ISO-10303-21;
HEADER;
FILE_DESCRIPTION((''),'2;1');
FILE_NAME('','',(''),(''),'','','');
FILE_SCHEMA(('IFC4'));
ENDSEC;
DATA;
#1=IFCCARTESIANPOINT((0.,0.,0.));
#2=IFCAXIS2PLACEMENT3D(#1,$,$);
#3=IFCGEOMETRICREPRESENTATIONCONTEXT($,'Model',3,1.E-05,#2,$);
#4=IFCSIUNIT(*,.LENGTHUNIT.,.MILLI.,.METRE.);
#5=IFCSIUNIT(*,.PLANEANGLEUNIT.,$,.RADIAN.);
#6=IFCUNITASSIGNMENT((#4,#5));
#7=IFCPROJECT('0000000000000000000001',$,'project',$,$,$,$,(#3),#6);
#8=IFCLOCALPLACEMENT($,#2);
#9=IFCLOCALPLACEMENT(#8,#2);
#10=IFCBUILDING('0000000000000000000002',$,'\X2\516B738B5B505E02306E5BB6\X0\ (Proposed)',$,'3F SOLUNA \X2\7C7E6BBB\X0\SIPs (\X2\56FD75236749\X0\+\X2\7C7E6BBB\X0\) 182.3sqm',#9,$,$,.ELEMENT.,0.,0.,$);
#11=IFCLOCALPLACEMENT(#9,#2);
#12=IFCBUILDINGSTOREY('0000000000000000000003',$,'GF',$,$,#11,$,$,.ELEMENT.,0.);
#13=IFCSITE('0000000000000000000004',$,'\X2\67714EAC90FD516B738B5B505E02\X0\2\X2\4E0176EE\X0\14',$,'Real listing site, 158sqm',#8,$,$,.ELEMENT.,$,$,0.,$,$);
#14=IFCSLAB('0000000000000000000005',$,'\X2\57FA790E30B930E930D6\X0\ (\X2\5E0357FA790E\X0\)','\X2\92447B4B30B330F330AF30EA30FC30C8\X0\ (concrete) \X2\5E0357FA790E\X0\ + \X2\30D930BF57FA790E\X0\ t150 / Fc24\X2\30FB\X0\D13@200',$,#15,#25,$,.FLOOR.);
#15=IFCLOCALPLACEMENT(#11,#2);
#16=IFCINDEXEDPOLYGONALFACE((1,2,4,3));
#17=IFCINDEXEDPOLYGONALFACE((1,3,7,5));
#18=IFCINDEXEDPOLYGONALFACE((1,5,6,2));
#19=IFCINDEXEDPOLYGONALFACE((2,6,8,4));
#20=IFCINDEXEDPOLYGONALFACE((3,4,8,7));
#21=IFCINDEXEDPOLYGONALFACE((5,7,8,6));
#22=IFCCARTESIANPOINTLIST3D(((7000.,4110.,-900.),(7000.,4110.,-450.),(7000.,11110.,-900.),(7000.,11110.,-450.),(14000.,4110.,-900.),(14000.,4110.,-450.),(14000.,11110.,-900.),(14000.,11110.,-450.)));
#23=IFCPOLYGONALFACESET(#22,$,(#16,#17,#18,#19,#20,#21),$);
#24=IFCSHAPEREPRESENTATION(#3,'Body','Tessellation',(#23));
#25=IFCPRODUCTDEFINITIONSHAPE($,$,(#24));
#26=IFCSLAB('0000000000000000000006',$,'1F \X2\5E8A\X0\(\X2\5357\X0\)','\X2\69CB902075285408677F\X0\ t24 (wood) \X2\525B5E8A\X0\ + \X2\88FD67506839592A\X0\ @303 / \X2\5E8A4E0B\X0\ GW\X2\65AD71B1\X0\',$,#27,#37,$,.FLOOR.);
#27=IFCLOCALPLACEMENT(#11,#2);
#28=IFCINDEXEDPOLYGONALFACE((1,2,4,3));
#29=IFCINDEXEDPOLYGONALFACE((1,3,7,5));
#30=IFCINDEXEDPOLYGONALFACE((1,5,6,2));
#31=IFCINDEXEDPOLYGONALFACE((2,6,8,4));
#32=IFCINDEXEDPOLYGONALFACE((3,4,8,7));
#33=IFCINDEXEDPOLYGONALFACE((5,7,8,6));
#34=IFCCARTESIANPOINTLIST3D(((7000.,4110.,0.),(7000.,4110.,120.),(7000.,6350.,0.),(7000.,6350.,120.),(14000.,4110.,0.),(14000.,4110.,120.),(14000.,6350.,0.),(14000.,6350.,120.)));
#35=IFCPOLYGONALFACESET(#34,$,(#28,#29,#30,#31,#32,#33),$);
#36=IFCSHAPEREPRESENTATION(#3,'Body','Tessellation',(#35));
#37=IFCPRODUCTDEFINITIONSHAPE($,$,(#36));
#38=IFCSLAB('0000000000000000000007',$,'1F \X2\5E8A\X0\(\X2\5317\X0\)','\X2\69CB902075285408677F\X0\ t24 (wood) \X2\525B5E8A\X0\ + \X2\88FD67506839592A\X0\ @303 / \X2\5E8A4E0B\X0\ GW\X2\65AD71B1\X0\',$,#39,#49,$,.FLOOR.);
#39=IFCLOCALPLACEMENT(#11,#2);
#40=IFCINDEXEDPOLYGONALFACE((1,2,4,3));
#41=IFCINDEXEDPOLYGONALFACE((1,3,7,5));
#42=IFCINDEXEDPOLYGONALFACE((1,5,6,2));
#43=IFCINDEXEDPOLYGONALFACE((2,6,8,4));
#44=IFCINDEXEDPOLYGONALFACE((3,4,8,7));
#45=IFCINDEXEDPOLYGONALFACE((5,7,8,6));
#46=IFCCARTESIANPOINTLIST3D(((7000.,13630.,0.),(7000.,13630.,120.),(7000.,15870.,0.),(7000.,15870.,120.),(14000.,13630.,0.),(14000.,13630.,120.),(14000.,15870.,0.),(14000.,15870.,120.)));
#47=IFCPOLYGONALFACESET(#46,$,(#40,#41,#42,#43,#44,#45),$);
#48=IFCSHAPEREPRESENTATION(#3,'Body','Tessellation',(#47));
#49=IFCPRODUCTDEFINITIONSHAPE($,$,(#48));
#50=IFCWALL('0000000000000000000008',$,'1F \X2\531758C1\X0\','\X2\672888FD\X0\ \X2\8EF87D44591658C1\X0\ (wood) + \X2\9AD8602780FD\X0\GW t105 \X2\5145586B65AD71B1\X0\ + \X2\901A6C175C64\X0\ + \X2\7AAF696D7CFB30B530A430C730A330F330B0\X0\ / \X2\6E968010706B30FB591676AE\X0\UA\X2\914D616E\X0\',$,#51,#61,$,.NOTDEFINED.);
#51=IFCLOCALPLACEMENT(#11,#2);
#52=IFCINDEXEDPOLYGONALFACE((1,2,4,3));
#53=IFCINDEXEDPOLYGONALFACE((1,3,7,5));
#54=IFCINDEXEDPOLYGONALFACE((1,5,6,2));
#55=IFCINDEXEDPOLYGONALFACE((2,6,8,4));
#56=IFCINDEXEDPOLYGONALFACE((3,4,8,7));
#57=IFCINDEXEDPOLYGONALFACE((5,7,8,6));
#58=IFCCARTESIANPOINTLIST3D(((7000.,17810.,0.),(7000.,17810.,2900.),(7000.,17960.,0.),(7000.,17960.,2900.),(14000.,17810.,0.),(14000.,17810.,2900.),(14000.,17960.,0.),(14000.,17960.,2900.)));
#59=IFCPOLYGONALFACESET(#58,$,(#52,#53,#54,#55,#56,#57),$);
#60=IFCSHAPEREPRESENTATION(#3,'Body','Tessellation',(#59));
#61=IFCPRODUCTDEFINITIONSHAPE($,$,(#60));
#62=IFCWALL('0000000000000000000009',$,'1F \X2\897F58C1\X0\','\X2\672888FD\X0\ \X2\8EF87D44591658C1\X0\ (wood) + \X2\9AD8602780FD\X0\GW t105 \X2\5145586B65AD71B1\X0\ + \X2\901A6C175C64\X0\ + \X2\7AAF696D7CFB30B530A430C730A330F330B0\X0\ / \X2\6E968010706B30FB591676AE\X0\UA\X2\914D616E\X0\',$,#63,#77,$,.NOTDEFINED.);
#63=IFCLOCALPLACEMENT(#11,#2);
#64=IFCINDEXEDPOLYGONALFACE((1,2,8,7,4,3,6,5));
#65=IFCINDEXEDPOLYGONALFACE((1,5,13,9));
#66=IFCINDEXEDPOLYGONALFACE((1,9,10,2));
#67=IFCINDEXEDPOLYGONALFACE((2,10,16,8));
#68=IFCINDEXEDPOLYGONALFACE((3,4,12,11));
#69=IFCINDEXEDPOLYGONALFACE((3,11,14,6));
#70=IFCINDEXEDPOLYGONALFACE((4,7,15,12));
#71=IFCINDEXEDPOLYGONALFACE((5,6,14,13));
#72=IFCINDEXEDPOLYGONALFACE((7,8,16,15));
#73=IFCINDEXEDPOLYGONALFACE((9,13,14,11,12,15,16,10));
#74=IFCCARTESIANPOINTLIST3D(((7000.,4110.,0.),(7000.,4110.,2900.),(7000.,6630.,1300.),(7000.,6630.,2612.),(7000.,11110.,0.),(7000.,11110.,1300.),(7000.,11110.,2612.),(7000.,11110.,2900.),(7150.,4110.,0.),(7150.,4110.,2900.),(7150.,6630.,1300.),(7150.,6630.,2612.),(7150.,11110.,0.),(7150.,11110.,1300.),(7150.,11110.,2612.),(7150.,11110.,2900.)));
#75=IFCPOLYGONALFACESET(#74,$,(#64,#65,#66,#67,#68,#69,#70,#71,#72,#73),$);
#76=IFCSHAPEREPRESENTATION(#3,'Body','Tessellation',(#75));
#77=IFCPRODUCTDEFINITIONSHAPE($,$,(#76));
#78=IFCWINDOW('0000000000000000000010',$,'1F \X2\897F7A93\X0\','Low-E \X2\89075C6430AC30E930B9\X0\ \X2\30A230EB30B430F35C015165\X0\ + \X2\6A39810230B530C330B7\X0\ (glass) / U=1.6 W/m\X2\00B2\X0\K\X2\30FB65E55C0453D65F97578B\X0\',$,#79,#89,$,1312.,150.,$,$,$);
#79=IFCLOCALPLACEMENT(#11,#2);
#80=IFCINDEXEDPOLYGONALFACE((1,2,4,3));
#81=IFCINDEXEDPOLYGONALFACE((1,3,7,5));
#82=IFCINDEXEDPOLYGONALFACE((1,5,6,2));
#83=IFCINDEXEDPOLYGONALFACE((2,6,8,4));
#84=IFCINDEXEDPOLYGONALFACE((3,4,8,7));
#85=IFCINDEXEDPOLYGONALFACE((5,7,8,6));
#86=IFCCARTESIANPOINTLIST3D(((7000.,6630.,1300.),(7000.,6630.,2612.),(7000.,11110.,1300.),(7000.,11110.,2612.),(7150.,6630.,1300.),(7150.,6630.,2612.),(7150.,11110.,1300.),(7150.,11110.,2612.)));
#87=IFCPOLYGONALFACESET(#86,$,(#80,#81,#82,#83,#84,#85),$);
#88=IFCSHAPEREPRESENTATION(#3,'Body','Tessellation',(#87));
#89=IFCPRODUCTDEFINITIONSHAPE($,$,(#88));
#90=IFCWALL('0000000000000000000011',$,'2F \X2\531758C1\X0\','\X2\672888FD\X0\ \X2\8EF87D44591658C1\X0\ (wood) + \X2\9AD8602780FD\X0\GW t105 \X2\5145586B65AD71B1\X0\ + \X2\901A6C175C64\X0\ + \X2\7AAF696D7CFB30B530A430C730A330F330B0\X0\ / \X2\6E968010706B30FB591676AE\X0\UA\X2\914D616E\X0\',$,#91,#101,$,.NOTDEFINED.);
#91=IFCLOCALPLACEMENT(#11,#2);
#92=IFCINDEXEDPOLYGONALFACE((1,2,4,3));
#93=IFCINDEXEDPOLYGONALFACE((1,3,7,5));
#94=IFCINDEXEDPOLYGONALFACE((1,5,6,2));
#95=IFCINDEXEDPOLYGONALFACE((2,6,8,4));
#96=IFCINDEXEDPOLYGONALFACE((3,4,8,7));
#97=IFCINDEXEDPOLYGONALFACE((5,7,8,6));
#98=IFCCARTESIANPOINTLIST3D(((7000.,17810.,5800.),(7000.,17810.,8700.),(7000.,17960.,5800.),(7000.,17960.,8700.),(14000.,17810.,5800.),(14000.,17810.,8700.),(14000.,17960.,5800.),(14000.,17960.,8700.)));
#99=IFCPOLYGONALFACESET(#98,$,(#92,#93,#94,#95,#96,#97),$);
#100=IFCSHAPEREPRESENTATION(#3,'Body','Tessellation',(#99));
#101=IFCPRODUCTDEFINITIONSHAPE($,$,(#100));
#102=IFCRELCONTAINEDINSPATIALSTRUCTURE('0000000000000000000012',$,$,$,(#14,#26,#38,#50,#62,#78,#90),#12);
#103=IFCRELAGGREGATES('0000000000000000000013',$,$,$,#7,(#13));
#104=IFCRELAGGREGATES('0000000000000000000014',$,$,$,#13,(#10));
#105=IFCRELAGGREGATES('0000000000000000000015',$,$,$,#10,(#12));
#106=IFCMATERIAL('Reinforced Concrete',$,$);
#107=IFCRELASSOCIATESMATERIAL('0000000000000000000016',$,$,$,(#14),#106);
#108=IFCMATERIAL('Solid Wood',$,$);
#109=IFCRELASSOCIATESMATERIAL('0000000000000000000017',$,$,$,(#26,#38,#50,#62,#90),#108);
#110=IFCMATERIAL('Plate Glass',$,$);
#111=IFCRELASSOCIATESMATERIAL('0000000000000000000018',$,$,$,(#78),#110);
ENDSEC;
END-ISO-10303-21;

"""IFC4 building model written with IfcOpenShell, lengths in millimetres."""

from ifc_helpers import new_model, si_unit, frame, frame_2d, origin, place, context, project, spatial, rectangle, extrude, material, element, fill, save


model = new_model("IFC4")

# Units and contexts
model_context = context("Model", 3, precision=1e-05, world=origin())
ifc_project = project(units=[si_unit("LENGTHUNIT", "METRE", prefix="MILLI"), si_unit("PLANEANGLEUNIT", "RADIAN")], contexts=[model_context])

# Site, building, storey
site_placement = place(None, origin())
site = spatial("IfcSite", under=ifc_project, at=site_placement, Name="東京都八王子市2丁目14", ObjectType="Real listing site, 158sqm", CompositionType="ELEMENT", RefElevation=0.0)
building_placement = place(site_placement, origin())
building = spatial("IfcBuilding", under=site, at=building_placement, Name="八王子市の家 (Proposed)", ObjectType="3F SOLUNA 籾殻SIPs (国産杉+籾殻) 182.3sqm", CompositionType="ELEMENT", ElevationOfRefHeight=0.0, ElevationOfTerrain=0.0)
storey_placement = place(building_placement, origin())
storey = spatial("IfcBuildingStorey", under=building, at=storey_placement, Name="GF", CompositionType="ELEMENT", Elevation=0.0)

# Slabs
ifc_material_1 = material(Name="Reinforced Concrete")
slab_1_placement = place(storey_placement, frame((3500.0, 2055.0, -450.0)))
element("IfcSlab", 1, at=slab_1_placement, inside=storey, material=ifc_material_1, Name="基礎スラブ (布基礎)", Description="鉄筋コンクリート (concrete) 布基礎 + ベタ基礎 t150 / Fc24・D13@200", PredefinedType="FLOOR", context=model_context, shape_type="SweptSolid", body=[
    extrude(rectangle(XDim=7000.0, YDim=7000.0, at=frame_2d((3500.0, 3500.0))), frame((3500.0, 2055.0, -450.0)), (0.0, 0.0, 1.0), 450.0),
])
ifc_material_2 = material(Name="Solid Wood")
slab_2_placement = place(storey_placement, frame((3500.0, 2055.0, 0.0)))
element("IfcSlab", 2, at=slab_2_placement, inside=storey, material=ifc_material_2, Name="1F 床(南)", Description="構造用合板 t24 (wood) 剛床 + 製材根太 @303 / 床下 GW断熱", PredefinedType="FLOOR", context=model_context, shape_type="SweptSolid", body=[
    extrude(rectangle(XDim=7000.0, YDim=2240.0, at=frame_2d((3500.0, 1120.0))), frame((3500.0, 2055.0, 0.0)), (0.0, 0.0, 1.0), 120.0),
])
slab_3_placement = place(storey_placement, frame((3500.0, 6815.0, 0.0)))
element("IfcSlab", 3, at=slab_3_placement, inside=storey, material=ifc_material_2, Name="1F 床(北)", Description="構造用合板 t24 (wood) 剛床 + 製材根太 @303 / 床下 GW断熱", PredefinedType="FLOOR", context=model_context, shape_type="SweptSolid", body=[
    extrude(rectangle(XDim=7000.0, YDim=2240.0, at=frame_2d((3500.0, 1120.0))), frame((3500.0, 6815.0, 0.0)), (0.0, 0.0, 1.0), 120.0),
])

# Shared definitions
ifc_material_3 = material(Name="Plate Glass")

# Wall
wall_1_placement = place(storey_placement, frame((3500.0, 8905.0, 0.0)))
element("IfcWall", 4, at=wall_1_placement, inside=storey, material=ifc_material_2, Name="1F 北壁", Description="木製 軸組外壁 (wood) + 高性能GW t105 充填断熱 + 通気層 + 窯業系サイディング / 準耐火・外皮UA配慮", PredefinedType="NOTDEFINED", context=model_context, shape_type="SweptSolid", body=[
    extrude(rectangle(XDim=7000.0, YDim=150.0, at=frame_2d((3500.0, 75.0))), frame((3500.0, 8905.0, 0.0)), (0.0, 0.0, 1.0), 2900.0),
])

# Wall, opening, window
wall_2_placement = place(storey_placement, frame((3500.0, 2055.0, 0.0)))
wall_2 = element("IfcWall", 5, at=wall_2_placement, inside=storey, material=ifc_material_2, Name="1F 西壁", Description="木製 軸組外壁 (wood) + 高性能GW t105 充填断熱 + 通気層 + 窯業系サイディング / 準耐火・外皮UA配慮", PredefinedType="NOTDEFINED", context=model_context, shape_type="SweptSolid", body=[
    extrude(rectangle(XDim=150.0, YDim=7000.0, at=frame_2d((75.0, 3500.0))), frame((3500.0, 2055.0, 0.0)), (0.0, 0.0, 1.0), 2900.0),
])
opening_1_placement = place(storey_placement, frame((3500.0, 3315.0, 650.0)))
opening_1 = element("IfcOpeningElement", 6, at=opening_1_placement, cuts=wall_2, PredefinedType="NOTDEFINED", context=model_context, shape_type="SweptSolid", body=[
    extrude(rectangle(XDim=150.0, YDim=4480.0, at=frame_2d((75.0, 2240.0))), frame((3500.0, 3315.0, 650.0)), (0.0, 0.0, 1.0), 1312.0),
])
window_1_placement = place(storey_placement, frame((3500.0, 3315.0, 650.0)))
window_1 = element("IfcWindow", 7, at=window_1_placement, inside=storey, material=ifc_material_3, Name="1F 西窓", Description="Low-E 複層ガラス アルゴン封入 + 樹脂サッシ (glass) / U=1.6 W/m²K・日射取得型", OverallHeight=1312.0, OverallWidth=150.0, context=model_context, shape_type="SweptSolid", body=[
    extrude(rectangle(XDim=150.0, YDim=4480.0, at=frame_2d((75.0, 2240.0))), frame((3500.0, 3315.0, 650.0)), (0.0, 0.0, 1.0), 1312.0),
])
fill(opening_1, window_1)

# Wall
wall_3_placement = place(storey_placement, frame((3500.0, 8905.0, 2900.0)))
element("IfcWall", 8, at=wall_3_placement, inside=storey, material=ifc_material_2, Name="2F 北壁", Description="木製 軸組外壁 (wood) + 高性能GW t105 充填断熱 + 通気層 + 窯業系サイディング / 準耐火・外皮UA配慮", PredefinedType="NOTDEFINED", context=model_context, shape_type="SweptSolid", body=[
    extrude(rectangle(XDim=7000.0, YDim=150.0, at=frame_2d((3500.0, 75.0))), frame((3500.0, 8905.0, 2900.0)), (0.0, 0.0, 1.0), 2900.0),
])

save(model, "model.ifc")
